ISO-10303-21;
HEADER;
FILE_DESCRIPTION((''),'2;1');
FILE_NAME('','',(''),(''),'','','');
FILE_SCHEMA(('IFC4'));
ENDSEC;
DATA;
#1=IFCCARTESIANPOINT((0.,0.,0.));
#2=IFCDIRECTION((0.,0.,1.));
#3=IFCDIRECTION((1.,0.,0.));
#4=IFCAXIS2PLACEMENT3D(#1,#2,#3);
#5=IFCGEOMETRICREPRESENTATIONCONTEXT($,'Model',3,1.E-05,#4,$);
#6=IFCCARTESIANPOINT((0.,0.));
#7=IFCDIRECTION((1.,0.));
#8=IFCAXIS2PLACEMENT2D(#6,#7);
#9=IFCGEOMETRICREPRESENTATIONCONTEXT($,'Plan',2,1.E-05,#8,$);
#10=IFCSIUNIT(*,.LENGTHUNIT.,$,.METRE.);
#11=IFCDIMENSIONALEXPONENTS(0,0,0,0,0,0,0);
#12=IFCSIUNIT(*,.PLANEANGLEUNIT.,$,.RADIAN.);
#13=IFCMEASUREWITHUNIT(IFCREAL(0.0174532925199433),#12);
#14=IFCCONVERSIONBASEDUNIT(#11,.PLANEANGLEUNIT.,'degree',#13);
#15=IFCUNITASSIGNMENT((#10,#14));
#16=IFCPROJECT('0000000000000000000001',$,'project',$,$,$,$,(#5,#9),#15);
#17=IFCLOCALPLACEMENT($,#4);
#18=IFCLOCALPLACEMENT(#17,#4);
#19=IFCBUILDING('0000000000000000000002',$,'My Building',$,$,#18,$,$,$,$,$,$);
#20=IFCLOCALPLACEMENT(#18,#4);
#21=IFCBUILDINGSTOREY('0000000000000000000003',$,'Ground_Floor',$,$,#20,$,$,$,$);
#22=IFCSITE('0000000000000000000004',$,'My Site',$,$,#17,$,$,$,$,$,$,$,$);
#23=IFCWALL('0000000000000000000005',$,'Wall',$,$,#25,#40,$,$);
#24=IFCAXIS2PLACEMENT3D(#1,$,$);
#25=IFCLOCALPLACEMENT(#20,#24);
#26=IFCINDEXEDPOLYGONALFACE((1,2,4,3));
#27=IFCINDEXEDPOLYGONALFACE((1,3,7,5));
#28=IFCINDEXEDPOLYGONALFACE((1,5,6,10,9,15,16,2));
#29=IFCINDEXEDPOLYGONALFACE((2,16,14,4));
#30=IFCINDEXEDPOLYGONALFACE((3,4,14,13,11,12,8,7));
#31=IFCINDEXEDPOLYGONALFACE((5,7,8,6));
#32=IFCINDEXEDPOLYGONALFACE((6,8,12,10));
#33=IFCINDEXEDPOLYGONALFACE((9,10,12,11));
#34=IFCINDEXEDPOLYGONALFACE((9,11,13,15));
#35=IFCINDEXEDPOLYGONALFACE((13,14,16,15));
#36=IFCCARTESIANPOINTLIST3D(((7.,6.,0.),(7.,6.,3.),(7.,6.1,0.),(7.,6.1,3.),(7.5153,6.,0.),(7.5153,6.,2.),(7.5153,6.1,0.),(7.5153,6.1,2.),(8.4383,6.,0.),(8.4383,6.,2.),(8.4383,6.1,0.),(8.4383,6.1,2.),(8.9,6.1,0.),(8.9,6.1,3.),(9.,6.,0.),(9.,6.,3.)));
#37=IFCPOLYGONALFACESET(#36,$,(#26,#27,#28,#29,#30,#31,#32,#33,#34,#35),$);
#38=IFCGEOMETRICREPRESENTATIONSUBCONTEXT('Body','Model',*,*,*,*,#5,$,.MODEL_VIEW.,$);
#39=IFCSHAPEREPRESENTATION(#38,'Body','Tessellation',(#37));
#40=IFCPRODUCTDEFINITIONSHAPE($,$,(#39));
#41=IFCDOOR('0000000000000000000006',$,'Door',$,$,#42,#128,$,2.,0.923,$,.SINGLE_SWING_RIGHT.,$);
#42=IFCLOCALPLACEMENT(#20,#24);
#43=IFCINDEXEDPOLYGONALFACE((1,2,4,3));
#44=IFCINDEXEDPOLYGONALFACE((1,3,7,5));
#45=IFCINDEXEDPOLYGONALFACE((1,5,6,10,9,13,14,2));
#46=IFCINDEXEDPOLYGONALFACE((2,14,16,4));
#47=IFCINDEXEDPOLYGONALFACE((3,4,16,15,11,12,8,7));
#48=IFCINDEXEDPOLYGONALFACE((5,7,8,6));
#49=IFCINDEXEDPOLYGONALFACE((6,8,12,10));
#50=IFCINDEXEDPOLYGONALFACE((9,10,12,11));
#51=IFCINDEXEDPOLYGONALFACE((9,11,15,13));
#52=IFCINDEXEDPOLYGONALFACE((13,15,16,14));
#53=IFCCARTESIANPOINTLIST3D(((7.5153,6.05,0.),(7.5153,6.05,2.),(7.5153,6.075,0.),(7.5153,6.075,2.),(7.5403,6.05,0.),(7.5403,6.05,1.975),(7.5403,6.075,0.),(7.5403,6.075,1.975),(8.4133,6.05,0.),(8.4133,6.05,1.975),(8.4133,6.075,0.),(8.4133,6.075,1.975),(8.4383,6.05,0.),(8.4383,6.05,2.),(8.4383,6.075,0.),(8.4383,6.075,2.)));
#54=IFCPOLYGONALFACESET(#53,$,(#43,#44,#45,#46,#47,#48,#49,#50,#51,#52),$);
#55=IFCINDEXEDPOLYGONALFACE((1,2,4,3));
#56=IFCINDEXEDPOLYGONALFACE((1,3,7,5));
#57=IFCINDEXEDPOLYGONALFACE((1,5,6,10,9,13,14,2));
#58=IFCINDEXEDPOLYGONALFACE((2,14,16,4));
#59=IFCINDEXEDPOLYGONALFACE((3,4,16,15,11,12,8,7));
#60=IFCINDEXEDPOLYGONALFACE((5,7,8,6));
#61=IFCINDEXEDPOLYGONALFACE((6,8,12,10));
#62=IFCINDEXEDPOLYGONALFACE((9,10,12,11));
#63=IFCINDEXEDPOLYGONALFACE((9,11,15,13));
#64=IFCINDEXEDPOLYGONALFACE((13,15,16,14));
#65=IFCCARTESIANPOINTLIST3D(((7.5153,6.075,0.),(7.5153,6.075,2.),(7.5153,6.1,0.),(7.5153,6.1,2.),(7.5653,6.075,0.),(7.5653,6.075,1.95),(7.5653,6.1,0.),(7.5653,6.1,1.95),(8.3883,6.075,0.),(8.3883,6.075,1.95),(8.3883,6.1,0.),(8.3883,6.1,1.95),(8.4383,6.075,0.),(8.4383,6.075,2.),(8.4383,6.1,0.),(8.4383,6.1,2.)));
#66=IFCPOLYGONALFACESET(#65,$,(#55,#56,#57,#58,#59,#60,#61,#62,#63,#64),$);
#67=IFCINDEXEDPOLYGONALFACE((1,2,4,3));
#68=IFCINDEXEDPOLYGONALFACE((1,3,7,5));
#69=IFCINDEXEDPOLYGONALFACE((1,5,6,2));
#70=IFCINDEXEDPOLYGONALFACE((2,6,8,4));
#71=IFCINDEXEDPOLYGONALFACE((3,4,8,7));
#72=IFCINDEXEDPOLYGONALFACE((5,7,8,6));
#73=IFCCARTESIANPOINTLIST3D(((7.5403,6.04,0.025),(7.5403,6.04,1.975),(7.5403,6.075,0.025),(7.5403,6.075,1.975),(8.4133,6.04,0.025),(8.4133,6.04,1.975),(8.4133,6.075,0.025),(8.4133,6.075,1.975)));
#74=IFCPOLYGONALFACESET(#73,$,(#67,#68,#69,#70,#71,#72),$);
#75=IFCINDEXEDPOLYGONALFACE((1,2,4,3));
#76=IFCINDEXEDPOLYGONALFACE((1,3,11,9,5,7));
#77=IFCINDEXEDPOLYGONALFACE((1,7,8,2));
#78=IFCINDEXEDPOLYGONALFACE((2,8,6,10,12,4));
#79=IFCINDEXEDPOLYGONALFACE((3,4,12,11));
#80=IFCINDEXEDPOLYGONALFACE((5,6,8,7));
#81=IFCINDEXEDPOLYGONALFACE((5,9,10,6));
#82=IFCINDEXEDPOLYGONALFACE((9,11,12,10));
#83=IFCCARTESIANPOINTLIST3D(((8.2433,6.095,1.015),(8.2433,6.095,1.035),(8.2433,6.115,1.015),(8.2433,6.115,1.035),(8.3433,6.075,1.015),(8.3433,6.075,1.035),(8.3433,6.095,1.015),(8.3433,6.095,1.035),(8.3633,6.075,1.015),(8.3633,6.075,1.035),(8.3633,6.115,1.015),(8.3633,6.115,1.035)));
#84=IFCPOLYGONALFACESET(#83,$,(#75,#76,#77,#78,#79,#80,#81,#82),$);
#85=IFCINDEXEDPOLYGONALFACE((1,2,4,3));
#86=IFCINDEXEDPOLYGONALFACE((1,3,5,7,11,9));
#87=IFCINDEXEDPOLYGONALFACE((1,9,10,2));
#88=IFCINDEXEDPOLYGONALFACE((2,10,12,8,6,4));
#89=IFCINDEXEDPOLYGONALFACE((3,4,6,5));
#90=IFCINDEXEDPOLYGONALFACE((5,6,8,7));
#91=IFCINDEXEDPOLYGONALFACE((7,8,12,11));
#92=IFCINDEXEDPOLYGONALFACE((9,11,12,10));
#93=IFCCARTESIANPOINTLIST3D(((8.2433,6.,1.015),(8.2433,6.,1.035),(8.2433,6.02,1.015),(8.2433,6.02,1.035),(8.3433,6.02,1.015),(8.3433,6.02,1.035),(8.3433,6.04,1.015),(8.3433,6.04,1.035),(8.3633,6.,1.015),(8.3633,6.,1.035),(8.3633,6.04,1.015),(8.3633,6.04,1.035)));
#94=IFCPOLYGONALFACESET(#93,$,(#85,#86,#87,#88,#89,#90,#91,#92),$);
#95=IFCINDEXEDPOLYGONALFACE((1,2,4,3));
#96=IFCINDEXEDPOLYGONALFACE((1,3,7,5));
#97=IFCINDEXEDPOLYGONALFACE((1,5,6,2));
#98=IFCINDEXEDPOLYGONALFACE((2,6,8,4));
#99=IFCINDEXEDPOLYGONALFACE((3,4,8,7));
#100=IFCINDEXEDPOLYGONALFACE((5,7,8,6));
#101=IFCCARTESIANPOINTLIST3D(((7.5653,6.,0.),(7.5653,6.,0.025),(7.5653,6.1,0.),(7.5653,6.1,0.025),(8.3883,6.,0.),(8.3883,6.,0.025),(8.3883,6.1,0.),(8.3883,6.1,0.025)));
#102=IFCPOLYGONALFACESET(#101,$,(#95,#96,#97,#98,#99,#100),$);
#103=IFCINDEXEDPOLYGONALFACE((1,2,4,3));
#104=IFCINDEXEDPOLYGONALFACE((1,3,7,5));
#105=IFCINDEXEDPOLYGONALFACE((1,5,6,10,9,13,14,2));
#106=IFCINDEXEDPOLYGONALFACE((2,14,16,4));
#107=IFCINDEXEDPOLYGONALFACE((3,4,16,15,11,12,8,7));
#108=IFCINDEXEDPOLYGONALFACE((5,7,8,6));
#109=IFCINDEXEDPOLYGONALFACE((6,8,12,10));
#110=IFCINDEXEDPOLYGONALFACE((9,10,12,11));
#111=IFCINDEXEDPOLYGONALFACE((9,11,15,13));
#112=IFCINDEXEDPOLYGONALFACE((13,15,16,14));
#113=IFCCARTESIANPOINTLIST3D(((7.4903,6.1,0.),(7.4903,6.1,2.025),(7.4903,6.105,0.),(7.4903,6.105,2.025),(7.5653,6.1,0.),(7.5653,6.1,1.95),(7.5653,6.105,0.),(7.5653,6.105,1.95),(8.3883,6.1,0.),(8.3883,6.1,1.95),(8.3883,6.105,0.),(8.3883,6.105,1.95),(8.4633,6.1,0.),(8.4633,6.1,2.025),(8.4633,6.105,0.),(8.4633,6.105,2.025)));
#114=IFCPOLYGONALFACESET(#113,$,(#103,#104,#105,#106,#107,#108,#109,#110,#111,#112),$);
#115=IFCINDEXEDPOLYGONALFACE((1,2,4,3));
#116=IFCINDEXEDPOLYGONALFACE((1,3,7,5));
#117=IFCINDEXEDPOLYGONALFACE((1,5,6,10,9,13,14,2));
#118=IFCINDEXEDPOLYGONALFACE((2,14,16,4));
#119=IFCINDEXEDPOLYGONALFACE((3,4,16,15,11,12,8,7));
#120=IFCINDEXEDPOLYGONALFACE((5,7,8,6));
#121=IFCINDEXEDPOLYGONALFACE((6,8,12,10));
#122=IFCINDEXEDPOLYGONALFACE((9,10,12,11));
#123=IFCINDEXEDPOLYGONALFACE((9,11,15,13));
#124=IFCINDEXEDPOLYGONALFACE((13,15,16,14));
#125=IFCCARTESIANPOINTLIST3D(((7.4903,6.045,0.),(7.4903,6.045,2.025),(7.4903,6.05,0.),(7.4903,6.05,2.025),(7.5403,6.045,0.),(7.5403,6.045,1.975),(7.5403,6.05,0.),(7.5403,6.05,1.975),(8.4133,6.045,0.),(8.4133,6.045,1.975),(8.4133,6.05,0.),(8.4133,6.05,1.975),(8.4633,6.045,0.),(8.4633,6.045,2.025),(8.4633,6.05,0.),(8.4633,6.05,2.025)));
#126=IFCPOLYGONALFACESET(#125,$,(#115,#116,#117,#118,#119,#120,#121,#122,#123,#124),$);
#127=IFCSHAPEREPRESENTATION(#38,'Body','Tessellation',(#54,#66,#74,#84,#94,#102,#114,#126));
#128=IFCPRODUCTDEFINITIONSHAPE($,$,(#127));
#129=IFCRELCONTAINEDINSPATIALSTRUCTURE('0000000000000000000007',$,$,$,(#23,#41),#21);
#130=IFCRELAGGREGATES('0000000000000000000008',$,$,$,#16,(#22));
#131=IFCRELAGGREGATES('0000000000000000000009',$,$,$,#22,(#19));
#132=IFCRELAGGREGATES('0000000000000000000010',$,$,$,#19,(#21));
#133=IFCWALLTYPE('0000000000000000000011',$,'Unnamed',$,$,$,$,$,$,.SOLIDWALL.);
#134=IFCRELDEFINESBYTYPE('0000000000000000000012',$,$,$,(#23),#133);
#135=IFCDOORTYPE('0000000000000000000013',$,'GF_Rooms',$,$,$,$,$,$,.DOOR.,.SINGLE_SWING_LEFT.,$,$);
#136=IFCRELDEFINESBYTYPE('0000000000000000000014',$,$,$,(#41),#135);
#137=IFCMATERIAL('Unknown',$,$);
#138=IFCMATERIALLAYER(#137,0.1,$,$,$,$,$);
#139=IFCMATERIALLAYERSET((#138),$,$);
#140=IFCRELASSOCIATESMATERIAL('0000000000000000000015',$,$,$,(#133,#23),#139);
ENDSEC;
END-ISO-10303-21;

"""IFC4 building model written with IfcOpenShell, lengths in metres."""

from ifc_helpers import new_model, entity, si_unit, converted_unit, frame, origin_with_axes, origin_2d_with_axis, place, context, subcontext, project, spatial, line, indexed_curve, outline, extrude, shape, source, transform, mapped, material, layer, layer_set, layer_usage, type_object, type_shapes, element, fill, save


model = new_model("IFC4")

# Units and contexts
model_context = context("Model", 3, precision=1e-05, world=origin_with_axes())
plan_context = context("Plan", 2, precision=1e-05, world=origin_2d_with_axis())
body_context_1 = subcontext(model_context, "Body", "Model", "MODEL_VIEW")
body_context_2 = subcontext(plan_context, "Body", "Plan", "PLAN_VIEW")
ifc_project = project(units=[si_unit("LENGTHUNIT", "METRE"), converted_unit("PLANEANGLEUNIT", "degree", entity("IfcReal", 0.0174532925199433), si_unit("PLANEANGLEUNIT", "RADIAN"), dimensions=[0, 0, 0, 0, 0, 0, 0])], contexts=[model_context, plan_context])

# Site, building, storey
site_placement = place(None, origin_with_axes())
site = spatial("IfcSite", under=ifc_project, at=site_placement, Name="My Site")
building_placement = place(site_placement, origin_with_axes())
building = spatial("IfcBuilding", under=site, at=building_placement, Name="My Building")
storey_placement = place(building_placement, origin_with_axes())
storey = spatial("IfcBuildingStorey", under=building, at=storey_placement, Name="Ground_Floor")

# Shared definitions
ifc_material = material(Name="Unknown")
ifc_layer = layer(ifc_material, 0.1)
ifc_layer_set = layer_set([ifc_layer])
wall_type = type_object("IfcWallType", Name="Unnamed", PredefinedType="SOLIDWALL", material=ifc_layer_set)
shared_shape_1 = source(origin_with_axes(), body_context_1, "Body", "SweptSolid", [
    extrude(outline(indexed_curve([(0.0, 0.0), (0.923, 0.0), (0.923, 2.0), (0.0, 2.0)], segments=[line(1, 2, 3, 4, 1)])), frame((0.0, -0.6, 0.0), z_axis=(0.0, -1.0, 0.0), x_axis=(1.0, 0.0, 0.0)), (0.0, 0.0, -1.0), 1.2),
])
door_type_1 = type_object("IfcDoorType", Name="GF_Rooms", OperationType="SINGLE_SWING_LEFT", PredefinedType="DOOR")
shared_shape_2 = source(origin_with_axes(), body_context_1, "Body", "SweptSolid", [
    extrude(outline(indexed_curve([(0.0, 0.0), (0.0, 2.0), (0.923, 2.0), (0.923, 0.0), (0.898, 0.0), (0.898, 1.975), (0.025, 1.975), (0.025, 0.0)], segments=[line(1, 2, 3, 4, 5, 6, 7, 8, 1)])), frame((0.0, 0.025, 0.0), z_axis=(0.0, -1.0, 0.0), x_axis=(1.0, 0.0, 0.0)), (0.0, 0.0, -1.0), 0.025),
    extrude(outline(indexed_curve([(0.0, 0.0), (0.0, 2.0), (0.923, 2.0), (0.923, 0.0), (0.873, 0.0), (0.873, 1.95), (0.05, 1.95), (0.05, 0.0)], segments=[line(1, 2, 3, 4, 5, 6, 7, 8, 1)])), frame((0.0, 0.0, 0.0), z_axis=(0.0, -1.0, 0.0), x_axis=(1.0, 0.0, 0.0)), (0.0, 0.0, -1.0), 0.025),
    extrude(outline(indexed_curve([(0.0, 0.0), (0.873, 0.0), (0.873, 0.035), (0.0, 0.035)], segments=[line(1, 2, 3, 4, 1)])), frame((0.025, 0.025, 0.025), z_axis=(0.0, 0.0, 1.0), x_axis=(1.0, 0.0, 0.0)), (0.0, 0.0, 1.0), 1.95),
    extrude(outline(indexed_curve([(0.0, 0.0), (0.0, -0.04), (0.12, -0.04), (0.12, -0.02), (0.02, -0.02), (0.02, 0.0)], segments=[line(1, 2, 3, 4, 5, 6, 1)])), frame((0.075, 0.025, 1.015), z_axis=(0.0, 0.0, 1.0), x_axis=(1.0, 0.0, 0.0)), (0.0, 0.0, 1.0), 0.02),
    extrude(outline(indexed_curve([(0.0, 0.0), (0.0, 0.04), (0.12, 0.04), (0.12, 0.02), (0.02, 0.02), (0.02, 0.0)], segments=[line(1, 2, 3, 4, 5, 6, 1)])), frame((0.075, 0.06, 1.015), z_axis=(0.0, 0.0, 1.0), x_axis=(1.0, 0.0, 0.0)), (0.0, 0.0, 1.0), 0.02),
    extrude(outline(indexed_curve([(0.0, 0.0), (0.823, 0.0), (0.823, 0.1), (0.0, 0.1)], segments=[line(1, 2, 3, 4, 1)])), frame((0.05, 0.0, 0.0), z_axis=(0.0, 0.0, 1.0), x_axis=(1.0, 0.0, 0.0)), (0.0, 0.0, 1.0), 0.025),
    extrude(outline(indexed_curve([(0.0, 0.0), (0.0, 2.025), (0.973, 2.025), (0.973, 0.0), (0.898, 0.0), (0.898, 1.95), (0.075, 1.95), (0.075, 0.0)], segments=[line(1, 2, 3, 4, 5, 6, 7, 8, 1)])), frame((-0.025, -0.005, 0.0), z_axis=(0.0, -1.0, 0.0), x_axis=(1.0, 0.0, 0.0)), (0.0, 0.0, -1.0), 0.005),
    extrude(outline(indexed_curve([(0.0, 0.0), (0.0, 2.025), (0.973, 2.025), (0.973, 0.0), (0.923, 0.0), (0.923, 1.975), (0.05, 1.975), (0.05, 0.0)], segments=[line(1, 2, 3, 4, 5, 6, 7, 8, 1)])), frame((-0.025, 0.05, 0.0), z_axis=(0.0, -1.0, 0.0), x_axis=(1.0, 0.0, 0.0)), (0.0, 0.0, -1.0), 0.005),
])
shared_shape_3 = source(origin_with_axes(), body_context_2, "Body", "Curve2D", [
    entity("IfcIndexedPolyCurve", entity("IfcCartesianPointList2D", [[0.0, 0.0], [0.0, 0.05], [0.025, 0.05], [0.025, 0.025], [0.05, 0.025], [0.05, 0.0]]), [entity("IfcLineIndex", [1, 2, 3, 4, 5, 6, 1])]),
    entity("IfcIndexedPolyCurve", entity("IfcCartesianPointList2D", [[0.923, 0.0], [0.923, 0.05], [0.898, 0.05], [0.898, 0.025], [0.873, 0.025], [0.873, 0.0]]), [entity("IfcLineIndex", [1, 2, 3, 4, 5, 6, 1])]),
    entity("IfcTrimmedCurve", entity("IfcEllipse", entity("IfcAxis2Placement2D", entity("IfcCartesianPoint", [0.863, 0.05]), entity("IfcDirection", [1.0, 0.0])), 0.838, 0.873), [entity("IfcCartesianPoint", [0.863, 0.923])], [entity("IfcCartesianPoint", [0.025, 0.05])], True, "CARTESIAN"),
    entity("IfcIndexedPolyCurve", entity("IfcCartesianPointList2D", [[0.898, 0.05], [0.863, 0.05], [0.863, 0.923], [0.898, 0.923]]), [entity("IfcLineIndex", [1, 2, 3, 4, 1])]),
])
type_shapes(door_type_1, [shared_shape_2, shared_shape_3])

# Wall, opening, door
ifc_layer_usage_1 = layer_usage(ifc_layer_set, "AXIS2", "POSITIVE", 0.0)
wall_1_placement = place(storey_placement, frame((7.0, 6.0, 0.0), z_axis=(0.0, 0.0, 1.0), x_axis=(1.0, 0.0, 0.0)))
wall_1 = element("IfcWall", 1, at=wall_1_placement, inside=storey, type_object=wall_type, material=ifc_layer_usage_1, Name="Wall", context=body_context_1, shape_type="SweptSolid", body=[
    extrude(outline(indexed_curve([(0.0, 0.0), (0.0, 0.1), (1.9, 0.1), (2.0, 0.0)], segments=[line(1, 2, 3, 4, 1)])), origin_with_axes(), (0.0, 0.0, 1.0), 3.0),
])
opening_1_placement = place(wall_1_placement, frame((1.4383, 0.1, 0.0), z_axis=(0.0, 0.0, 1.0), x_axis=(-1.0, 0.0, 0.0)))
opening_1 = element("IfcOpeningElement", 2, at=opening_1_placement, cuts=wall_1, PredefinedType="OPENING", context=body_context_1, shape_type="MappedRepresentation", body=[
    mapped(shared_shape_1, transform((0.0, 0.0, 0.0), x_axis=(1.0, 0.0, 0.0), y_axis=(0.0, 1.0, 0.0), z_axis=(0.0, 0.0, 1.0), scale=1.0)),
])
door_1_placement = place(opening_1_placement, origin_with_axes())
door_1 = element("IfcDoor", 3, at=door_1_placement, inside=storey, type_object=door_type_1, Name="Door", OperationType="SINGLE_SWING_RIGHT", OverallHeight=2.0, OverallWidth=0.923, shapes=[
    shape(body_context_1, "Body", "MappedRepresentation", [mapped(shared_shape_2, transform((0.0, 0.0, 0.0), x_axis=(1.0, 0.0, 0.0), y_axis=(0.0, 1.0, 0.0), z_axis=(0.0, 0.0, 1.0), scale=1.0))]),
    shape(body_context_2, "Body", "MappedRepresentation", [mapped(shared_shape_3, transform((0.0, 0.0, 0.0), x_axis=(1.0, 0.0, 0.0), y_axis=(0.0, 1.0, 0.0), z_axis=(0.0, 0.0, 1.0), scale=1.0))]),
])
fill(opening_1, door_1)

save(model, "model.ifc")
